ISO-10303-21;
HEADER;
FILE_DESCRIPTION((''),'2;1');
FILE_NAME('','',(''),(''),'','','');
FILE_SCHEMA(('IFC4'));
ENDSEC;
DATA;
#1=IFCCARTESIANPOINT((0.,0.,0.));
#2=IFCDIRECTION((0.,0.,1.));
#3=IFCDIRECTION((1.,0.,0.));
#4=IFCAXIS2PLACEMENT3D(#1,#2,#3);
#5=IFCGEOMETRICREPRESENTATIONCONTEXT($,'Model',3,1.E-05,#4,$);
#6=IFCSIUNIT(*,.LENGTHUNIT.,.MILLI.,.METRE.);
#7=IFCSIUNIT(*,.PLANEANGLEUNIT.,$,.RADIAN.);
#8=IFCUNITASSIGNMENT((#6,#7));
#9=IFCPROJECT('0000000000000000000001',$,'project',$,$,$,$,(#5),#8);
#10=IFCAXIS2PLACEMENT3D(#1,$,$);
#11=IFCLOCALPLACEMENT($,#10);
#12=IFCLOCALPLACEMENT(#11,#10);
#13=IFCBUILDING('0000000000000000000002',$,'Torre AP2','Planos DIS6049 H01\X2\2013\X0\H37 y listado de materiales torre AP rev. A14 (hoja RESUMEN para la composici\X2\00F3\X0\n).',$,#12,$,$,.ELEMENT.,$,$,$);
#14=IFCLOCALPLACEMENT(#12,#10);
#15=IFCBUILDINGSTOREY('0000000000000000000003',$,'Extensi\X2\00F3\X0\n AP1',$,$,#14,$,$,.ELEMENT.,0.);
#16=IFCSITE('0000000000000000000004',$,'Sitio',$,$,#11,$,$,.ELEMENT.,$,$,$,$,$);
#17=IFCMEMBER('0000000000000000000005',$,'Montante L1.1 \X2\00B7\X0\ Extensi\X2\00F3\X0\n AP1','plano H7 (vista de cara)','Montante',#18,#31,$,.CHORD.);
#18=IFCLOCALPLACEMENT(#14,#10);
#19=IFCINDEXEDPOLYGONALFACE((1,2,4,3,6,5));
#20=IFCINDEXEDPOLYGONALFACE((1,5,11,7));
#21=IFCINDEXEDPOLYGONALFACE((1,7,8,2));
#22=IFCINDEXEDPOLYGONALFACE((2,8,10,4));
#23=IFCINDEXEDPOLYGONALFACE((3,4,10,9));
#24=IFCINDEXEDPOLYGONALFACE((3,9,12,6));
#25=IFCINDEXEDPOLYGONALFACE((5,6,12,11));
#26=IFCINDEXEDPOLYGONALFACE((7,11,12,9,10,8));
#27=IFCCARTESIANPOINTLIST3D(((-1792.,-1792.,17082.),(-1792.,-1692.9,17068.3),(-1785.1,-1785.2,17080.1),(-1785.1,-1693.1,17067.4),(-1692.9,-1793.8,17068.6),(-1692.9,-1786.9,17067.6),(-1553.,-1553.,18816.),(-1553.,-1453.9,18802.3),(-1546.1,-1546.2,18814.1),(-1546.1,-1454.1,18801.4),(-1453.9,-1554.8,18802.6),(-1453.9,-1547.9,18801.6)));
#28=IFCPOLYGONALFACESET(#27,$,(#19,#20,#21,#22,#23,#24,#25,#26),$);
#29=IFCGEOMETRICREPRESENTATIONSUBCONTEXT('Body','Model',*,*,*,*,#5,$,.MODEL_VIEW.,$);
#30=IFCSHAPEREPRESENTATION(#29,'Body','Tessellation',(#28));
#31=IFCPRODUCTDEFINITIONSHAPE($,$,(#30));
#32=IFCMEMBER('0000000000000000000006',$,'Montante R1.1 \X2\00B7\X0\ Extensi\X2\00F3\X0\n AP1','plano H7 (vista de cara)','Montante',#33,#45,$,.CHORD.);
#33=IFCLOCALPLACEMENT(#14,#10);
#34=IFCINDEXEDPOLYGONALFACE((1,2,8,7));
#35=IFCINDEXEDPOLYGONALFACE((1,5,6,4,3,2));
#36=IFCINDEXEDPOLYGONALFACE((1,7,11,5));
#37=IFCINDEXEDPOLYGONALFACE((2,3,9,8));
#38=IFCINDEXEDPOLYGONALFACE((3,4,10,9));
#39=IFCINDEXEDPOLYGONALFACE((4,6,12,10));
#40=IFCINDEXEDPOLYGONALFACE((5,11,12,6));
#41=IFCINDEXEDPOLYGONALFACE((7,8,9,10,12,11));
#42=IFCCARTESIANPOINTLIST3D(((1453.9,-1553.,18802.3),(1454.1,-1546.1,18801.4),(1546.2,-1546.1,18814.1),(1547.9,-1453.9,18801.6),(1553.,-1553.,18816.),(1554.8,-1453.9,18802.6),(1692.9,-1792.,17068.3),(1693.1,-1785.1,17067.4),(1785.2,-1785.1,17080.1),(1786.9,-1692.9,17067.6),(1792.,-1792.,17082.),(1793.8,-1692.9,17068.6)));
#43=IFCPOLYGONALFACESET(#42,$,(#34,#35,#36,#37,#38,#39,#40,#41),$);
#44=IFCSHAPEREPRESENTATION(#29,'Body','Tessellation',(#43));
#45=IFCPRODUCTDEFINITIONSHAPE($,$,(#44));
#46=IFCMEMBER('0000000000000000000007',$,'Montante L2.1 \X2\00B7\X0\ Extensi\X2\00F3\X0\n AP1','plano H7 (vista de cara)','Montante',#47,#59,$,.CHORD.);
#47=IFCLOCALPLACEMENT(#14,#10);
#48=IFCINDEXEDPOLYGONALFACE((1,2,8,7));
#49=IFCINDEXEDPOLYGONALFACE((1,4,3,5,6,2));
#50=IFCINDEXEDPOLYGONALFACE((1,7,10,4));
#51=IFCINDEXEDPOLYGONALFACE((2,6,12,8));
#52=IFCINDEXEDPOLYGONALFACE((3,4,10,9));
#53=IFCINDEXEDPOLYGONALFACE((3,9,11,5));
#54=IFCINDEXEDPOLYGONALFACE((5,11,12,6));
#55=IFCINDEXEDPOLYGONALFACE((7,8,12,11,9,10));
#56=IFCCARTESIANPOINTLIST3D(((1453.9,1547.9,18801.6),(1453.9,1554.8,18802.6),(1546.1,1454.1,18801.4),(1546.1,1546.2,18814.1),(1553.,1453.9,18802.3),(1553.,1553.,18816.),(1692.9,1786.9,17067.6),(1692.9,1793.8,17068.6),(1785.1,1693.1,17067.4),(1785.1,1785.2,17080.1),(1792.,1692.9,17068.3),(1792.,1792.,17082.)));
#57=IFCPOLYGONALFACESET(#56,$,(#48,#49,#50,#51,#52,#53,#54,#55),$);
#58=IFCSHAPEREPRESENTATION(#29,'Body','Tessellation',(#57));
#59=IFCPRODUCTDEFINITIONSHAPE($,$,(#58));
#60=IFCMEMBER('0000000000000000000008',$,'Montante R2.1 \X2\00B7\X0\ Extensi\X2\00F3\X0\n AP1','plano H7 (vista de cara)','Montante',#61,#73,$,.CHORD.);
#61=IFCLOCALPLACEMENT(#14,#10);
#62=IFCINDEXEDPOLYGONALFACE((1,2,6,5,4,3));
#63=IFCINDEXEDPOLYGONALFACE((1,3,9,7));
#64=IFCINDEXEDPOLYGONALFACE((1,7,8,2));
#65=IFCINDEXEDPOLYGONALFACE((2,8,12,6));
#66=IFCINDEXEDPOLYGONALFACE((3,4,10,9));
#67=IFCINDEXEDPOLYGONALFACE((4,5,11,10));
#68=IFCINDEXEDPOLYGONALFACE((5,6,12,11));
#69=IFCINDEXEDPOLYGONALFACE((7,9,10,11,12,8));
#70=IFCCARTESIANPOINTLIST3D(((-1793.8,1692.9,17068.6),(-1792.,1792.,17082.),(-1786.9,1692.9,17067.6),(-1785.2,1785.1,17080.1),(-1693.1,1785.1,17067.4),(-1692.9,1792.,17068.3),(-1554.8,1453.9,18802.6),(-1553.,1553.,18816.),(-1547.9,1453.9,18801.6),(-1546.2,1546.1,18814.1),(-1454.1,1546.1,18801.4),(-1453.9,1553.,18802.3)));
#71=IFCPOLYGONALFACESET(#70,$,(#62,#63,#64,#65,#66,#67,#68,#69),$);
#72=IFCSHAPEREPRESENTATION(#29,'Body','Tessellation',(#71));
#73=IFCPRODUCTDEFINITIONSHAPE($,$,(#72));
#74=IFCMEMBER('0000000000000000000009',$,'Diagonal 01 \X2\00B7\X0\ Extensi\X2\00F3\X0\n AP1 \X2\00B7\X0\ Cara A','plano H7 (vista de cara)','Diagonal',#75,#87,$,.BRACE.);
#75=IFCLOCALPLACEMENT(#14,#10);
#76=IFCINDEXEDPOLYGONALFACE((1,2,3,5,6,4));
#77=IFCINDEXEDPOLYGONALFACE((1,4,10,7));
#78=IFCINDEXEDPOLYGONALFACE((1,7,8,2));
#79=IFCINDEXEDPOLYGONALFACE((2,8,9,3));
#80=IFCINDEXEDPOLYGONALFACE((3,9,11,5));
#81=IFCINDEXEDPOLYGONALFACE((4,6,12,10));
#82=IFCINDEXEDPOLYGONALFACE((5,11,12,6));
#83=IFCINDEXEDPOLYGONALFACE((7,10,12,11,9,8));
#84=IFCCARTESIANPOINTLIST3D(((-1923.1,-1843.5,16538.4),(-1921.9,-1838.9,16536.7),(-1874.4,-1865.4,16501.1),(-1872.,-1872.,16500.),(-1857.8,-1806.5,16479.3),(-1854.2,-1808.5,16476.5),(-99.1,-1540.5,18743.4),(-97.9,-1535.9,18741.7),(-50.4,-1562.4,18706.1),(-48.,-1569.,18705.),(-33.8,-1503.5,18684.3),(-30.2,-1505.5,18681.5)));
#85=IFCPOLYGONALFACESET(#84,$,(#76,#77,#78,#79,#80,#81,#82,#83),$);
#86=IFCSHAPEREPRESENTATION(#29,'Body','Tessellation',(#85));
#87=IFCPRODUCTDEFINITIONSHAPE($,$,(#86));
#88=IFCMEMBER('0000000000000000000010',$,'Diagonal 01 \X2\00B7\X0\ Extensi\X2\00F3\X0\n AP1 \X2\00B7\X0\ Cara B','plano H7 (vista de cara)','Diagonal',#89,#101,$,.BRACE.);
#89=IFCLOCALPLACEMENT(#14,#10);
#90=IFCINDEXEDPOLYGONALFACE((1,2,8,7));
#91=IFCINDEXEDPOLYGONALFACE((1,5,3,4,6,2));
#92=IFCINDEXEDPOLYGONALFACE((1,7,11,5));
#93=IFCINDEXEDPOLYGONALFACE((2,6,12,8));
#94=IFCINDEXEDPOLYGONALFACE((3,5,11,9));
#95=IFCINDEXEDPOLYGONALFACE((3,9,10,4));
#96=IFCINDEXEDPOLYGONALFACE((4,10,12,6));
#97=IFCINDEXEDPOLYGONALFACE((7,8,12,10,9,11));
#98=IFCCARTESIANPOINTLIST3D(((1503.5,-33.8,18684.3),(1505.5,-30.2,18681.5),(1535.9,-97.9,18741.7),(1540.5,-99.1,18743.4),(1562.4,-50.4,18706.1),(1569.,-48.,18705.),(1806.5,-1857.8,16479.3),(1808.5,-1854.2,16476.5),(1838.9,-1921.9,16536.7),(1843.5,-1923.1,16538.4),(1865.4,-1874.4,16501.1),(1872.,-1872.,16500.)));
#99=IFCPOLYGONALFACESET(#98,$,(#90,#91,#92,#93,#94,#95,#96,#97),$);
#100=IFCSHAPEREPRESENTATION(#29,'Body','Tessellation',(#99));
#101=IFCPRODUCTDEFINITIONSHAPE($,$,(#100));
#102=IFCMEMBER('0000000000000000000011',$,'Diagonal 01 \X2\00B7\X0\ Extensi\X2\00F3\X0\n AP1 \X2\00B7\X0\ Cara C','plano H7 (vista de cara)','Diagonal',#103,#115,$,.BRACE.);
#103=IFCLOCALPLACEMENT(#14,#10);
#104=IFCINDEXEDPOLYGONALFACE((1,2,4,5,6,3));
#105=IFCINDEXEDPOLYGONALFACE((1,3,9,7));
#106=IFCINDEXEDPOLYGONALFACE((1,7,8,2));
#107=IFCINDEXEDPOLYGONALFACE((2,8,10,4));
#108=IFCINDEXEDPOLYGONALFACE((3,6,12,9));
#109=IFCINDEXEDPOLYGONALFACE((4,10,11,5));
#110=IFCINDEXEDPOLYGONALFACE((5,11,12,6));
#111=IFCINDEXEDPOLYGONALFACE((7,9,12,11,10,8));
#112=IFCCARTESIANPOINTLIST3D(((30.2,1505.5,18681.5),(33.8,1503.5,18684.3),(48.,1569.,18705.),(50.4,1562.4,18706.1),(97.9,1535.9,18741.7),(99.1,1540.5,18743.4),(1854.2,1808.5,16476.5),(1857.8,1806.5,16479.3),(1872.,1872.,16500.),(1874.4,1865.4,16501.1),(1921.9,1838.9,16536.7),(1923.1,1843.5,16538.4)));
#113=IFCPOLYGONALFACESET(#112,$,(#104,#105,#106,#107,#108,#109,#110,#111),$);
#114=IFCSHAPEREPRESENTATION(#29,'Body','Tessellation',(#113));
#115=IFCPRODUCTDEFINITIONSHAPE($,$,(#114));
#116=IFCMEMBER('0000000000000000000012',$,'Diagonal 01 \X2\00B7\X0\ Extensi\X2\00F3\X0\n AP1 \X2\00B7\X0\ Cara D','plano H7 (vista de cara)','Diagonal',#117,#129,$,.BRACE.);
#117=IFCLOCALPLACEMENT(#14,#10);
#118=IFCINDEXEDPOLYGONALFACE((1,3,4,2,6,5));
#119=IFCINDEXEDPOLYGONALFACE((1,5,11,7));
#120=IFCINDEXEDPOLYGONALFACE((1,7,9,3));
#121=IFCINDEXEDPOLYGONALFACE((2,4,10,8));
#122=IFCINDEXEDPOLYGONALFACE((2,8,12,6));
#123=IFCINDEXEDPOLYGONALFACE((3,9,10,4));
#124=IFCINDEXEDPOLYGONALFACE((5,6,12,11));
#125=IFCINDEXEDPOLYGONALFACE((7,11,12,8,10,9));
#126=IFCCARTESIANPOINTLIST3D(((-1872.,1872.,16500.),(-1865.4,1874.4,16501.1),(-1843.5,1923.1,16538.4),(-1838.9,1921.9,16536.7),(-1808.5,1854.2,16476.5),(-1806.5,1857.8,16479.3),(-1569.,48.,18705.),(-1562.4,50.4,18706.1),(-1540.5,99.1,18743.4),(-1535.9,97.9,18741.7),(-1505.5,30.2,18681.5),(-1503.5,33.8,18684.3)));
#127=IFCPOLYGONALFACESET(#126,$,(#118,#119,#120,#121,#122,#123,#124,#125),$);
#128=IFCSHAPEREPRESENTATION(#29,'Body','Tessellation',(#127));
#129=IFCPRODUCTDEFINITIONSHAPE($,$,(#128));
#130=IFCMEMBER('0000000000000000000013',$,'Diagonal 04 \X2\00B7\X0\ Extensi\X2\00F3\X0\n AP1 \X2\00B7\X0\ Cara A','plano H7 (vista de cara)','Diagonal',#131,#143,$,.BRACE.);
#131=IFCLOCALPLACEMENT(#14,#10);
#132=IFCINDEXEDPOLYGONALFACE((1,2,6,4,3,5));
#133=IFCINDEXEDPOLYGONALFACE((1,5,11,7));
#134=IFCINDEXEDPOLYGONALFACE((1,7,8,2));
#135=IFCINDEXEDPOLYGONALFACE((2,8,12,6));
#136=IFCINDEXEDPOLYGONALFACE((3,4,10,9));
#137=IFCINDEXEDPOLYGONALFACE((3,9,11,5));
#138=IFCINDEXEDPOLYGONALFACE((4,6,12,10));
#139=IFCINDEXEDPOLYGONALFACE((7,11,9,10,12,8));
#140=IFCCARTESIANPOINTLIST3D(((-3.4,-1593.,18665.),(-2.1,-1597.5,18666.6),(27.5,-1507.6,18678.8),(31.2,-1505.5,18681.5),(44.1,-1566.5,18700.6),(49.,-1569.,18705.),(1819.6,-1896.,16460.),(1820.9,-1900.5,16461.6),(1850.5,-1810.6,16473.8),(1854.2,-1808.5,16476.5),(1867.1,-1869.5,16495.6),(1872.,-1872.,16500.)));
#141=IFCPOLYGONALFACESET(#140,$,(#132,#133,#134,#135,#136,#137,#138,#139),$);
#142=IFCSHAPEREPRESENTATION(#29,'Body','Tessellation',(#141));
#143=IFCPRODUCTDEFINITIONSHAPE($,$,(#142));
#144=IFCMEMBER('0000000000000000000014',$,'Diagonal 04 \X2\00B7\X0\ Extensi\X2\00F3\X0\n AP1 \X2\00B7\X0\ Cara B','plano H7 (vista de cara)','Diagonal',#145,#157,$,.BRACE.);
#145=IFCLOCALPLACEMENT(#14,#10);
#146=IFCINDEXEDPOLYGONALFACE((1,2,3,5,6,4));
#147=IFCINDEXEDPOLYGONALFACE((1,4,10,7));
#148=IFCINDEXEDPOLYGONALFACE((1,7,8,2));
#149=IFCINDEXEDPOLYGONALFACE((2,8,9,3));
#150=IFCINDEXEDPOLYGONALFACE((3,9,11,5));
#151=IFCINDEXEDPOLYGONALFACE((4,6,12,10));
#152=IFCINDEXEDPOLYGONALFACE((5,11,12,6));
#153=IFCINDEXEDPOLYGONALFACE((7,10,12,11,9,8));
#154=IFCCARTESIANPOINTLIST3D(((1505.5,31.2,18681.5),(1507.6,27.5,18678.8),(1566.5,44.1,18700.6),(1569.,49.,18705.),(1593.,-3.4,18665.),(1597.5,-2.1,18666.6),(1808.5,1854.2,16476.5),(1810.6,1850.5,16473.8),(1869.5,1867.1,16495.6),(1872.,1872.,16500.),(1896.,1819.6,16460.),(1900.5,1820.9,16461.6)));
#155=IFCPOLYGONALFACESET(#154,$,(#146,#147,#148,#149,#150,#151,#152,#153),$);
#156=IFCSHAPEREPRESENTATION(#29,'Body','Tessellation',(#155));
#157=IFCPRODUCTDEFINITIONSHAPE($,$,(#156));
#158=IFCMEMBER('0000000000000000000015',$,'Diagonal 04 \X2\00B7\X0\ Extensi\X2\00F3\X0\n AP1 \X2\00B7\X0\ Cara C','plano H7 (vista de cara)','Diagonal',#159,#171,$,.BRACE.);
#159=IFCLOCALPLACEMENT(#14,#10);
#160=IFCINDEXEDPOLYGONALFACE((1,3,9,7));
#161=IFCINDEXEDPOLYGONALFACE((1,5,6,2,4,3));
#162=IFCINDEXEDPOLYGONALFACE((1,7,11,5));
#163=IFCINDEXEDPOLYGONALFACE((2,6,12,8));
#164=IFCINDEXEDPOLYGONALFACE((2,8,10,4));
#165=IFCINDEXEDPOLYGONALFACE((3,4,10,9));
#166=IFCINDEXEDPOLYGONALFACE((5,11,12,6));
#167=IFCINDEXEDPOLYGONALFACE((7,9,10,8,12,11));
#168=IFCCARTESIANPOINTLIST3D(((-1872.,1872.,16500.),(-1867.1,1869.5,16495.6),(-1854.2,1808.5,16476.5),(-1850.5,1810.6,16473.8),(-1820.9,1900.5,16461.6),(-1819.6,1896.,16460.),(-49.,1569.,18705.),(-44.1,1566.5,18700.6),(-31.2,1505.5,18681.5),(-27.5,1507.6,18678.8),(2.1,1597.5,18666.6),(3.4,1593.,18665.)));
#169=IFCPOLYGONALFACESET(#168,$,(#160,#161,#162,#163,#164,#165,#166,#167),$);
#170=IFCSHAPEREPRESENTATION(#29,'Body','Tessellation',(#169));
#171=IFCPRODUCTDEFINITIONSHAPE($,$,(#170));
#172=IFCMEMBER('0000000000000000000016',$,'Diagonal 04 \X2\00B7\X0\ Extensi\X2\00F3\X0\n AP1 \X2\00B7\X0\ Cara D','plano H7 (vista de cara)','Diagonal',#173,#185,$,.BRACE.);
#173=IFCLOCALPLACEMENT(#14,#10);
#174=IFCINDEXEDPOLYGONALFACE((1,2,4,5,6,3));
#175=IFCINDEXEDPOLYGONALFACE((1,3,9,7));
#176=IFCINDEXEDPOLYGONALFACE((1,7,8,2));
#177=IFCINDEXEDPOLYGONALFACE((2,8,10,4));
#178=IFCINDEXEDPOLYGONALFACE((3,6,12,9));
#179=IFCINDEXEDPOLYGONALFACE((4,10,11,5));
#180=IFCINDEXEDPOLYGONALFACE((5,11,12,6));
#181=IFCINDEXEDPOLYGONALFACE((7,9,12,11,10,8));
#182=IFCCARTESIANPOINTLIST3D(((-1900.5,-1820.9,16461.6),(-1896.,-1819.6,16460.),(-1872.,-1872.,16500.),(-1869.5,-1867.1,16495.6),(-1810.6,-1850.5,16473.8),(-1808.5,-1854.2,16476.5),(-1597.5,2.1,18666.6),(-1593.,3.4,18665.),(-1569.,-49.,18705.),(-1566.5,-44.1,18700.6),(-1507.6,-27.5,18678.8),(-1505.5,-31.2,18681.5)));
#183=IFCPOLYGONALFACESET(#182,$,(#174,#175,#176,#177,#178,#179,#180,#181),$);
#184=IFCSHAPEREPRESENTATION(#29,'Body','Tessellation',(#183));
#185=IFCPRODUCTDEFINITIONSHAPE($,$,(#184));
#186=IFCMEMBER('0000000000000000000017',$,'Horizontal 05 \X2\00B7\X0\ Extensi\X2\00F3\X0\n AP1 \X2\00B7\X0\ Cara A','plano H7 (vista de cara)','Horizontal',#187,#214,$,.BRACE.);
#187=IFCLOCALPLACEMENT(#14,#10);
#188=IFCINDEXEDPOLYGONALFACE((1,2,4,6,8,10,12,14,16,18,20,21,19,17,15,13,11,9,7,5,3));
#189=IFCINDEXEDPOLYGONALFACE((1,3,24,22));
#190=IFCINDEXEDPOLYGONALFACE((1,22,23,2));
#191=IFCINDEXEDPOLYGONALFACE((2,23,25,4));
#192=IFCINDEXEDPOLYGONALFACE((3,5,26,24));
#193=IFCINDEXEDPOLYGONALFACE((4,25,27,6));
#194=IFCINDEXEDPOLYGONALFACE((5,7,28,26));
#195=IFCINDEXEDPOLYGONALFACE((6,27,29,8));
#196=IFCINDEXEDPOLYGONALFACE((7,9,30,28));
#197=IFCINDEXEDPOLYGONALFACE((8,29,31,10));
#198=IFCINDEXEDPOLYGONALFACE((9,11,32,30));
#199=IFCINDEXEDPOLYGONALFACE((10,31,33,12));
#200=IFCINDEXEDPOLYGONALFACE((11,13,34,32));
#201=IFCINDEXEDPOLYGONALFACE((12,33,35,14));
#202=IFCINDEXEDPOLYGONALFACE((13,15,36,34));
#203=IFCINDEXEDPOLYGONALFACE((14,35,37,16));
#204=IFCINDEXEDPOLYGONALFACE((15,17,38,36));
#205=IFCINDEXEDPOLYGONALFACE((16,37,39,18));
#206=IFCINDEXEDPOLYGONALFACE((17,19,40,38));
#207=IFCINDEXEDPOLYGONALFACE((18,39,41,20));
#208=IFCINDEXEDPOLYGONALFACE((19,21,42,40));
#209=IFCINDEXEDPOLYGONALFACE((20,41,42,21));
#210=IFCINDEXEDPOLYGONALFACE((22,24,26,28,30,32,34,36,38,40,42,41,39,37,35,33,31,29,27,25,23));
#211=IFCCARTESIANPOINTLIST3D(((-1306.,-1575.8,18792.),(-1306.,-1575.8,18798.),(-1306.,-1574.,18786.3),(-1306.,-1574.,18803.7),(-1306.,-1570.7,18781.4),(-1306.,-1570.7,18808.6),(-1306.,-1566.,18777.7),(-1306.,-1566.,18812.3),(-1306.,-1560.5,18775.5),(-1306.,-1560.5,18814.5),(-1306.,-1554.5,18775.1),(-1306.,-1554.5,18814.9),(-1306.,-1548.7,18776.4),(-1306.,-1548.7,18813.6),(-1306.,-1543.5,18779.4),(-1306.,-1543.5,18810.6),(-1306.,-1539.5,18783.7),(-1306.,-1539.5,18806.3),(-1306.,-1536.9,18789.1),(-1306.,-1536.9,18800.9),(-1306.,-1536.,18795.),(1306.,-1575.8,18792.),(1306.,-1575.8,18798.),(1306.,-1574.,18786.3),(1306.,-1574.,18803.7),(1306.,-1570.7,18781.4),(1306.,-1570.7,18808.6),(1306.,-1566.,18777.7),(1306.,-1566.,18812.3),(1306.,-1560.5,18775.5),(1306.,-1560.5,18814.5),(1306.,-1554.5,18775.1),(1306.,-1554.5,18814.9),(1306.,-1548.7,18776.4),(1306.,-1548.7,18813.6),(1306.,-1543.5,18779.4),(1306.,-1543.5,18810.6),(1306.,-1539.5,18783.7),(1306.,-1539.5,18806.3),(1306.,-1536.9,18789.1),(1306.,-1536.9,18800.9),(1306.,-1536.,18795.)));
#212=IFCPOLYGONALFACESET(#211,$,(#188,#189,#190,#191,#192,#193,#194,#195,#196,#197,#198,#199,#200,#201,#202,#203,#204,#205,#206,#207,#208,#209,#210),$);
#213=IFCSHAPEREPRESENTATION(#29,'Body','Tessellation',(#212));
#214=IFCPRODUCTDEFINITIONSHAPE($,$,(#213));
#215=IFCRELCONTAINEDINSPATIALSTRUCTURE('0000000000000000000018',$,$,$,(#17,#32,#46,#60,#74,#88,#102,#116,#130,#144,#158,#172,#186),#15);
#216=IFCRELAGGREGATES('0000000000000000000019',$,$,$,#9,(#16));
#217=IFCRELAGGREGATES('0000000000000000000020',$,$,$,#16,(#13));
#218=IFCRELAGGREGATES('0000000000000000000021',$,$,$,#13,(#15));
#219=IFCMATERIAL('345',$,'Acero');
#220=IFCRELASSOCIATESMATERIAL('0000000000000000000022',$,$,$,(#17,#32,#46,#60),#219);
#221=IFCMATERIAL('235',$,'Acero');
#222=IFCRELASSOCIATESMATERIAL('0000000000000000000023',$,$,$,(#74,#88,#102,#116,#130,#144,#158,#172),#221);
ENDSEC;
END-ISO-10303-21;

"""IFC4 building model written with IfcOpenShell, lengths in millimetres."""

from ifc_helpers import new_model, si_unit, frame, frame_2d, origin, origin_with_axes, place, context, subcontext, project, spatial, circle, l_section, extrude, material, element, save


model = new_model("IFC4")

# Units and contexts
model_context = context("Model", 3, precision=1e-05, world=origin_with_axes())
body_context = subcontext(model_context, "Body", "Model", "MODEL_VIEW")
ifc_project = project(units=[si_unit("LENGTHUNIT", "METRE", prefix="MILLI"), si_unit("PLANEANGLEUNIT", "RADIAN")], contexts=[model_context])

# Site, building, storey
site_placement = place(None, origin())
site = spatial("IfcSite", under=ifc_project, at=site_placement, Name="Sitio", CompositionType="ELEMENT")
building_placement = place(site_placement, origin())
building = spatial("IfcBuilding", under=site, at=building_placement, Name="Torre AP2", Description="Planos DIS6049 H01–H37 y listado de materiales torre AP rev. A14 (hoja RESUMEN para la composición).", CompositionType="ELEMENT")
storey_placement = place(building_placement, origin())
storey = spatial("IfcBuildingStorey", under=building, at=storey_placement, Name="Extensión AP1", CompositionType="ELEMENT", Elevation=0.0)

# Members
ifc_material_1 = material(Name="345", Category="Acero")
for number, where, z_axis, x_axis, name in (
    (1, (-1792.0, -1792.0, 17082.0), (0.135285, 0.135285, 0.981527), (0.990807, -0.018472, -0.134018), "Montante L1.1 · Extensión AP1"),
    (2, (1792.0, -1792.0, 17082.0), (-0.135285, 0.135285, 0.981527), (0.018472, 0.990807, -0.134018), "Montante R1.1 · Extensión AP1"),
    (3, (1792.0, 1792.0, 17082.0), (-0.135285, -0.135285, 0.981527), (-0.990807, 0.018472, -0.134018), "Montante L2.1 · Extensión AP1"),
    (4, (-1792.0, 1792.0, 17082.0), (0.135285, -0.135285, 0.981527), (-0.018472, -0.990807, -0.134018), "Montante R2.1 · Extensión AP1"),
):
    element("IfcMember", number, at=place(storey_placement, frame(where, z_axis=z_axis, x_axis=x_axis)), inside=storey, material=ifc_material_1, Name=name, Description="plano H7 (vista de cara)", ObjectType="Montante", PredefinedType="CHORD", context=body_context, shape_type="SweptSolid", body=[
        extrude(l_section(Depth=100.0, Width=100.0, Thickness=7.0, at=frame_2d((50.0, 50.0))), None, (0.0, 0.0, 1.0), 1766.6),
    ])
ifc_material_2 = material(Name="235", Category="Acero")
for number, where, z_axis, x_axis, name in (
    (5, (-1872.0, -1872.0, 16500.0), (0.633853, 0.105295, 0.766253), (0.25455, 0.907102, -0.335216), "Diagonal 01 · Extensión AP1 · Cara A"),
    (6, (1872.0, -1872.0, 16500.0), (-0.105295, 0.633853, 0.766253), (-0.907102, 0.25455, -0.335216), "Diagonal 01 · Extensión AP1 · Cara B"),
    (7, (1872.0, 1872.0, 16500.0), (-0.633853, -0.105295, 0.766253), (-0.25455, -0.907102, -0.335216), "Diagonal 01 · Extensión AP1 · Cara C"),
    (8, (-1872.0, 1872.0, 16500.0), (0.105295, -0.633853, 0.766253), (0.907102, -0.25455, -0.335216), "Diagonal 01 · Extensión AP1 · Cara D"),
):
    element("IfcMember", number, at=place(storey_placement, frame(where, z_axis=z_axis, x_axis=x_axis)), inside=storey, material=ifc_material_2, Name=name, Description="plano H7 (vista de cara)", ObjectType="Diagonal", PredefinedType="BRACE", context=body_context, shape_type="SweptSolid", body=[
        extrude(l_section(Depth=70.0, Width=70.0, Thickness=5.0, at=frame_2d((35.0, 35.0))), None, (0.0, 0.0, 1.0), 2877.6),
    ])
for number, where, z_axis, x_axis, name in (
    (9, (1872.0, -1872.0, 16500.0), (-0.633645, 0.105318, 0.766422), (-0.254835, 0.906984, -0.33532), "Diagonal 04 · Extensión AP1 · Cara A"),
    (10, (1872.0, 1872.0, 16500.0), (-0.105318, -0.633645, 0.766422), (-0.906984, -0.254835, -0.33532), "Diagonal 04 · Extensión AP1 · Cara B"),
    (11, (-1872.0, 1872.0, 16500.0), (0.633645, -0.105318, 0.766422), (0.254835, -0.906984, -0.33532), "Diagonal 04 · Extensión AP1 · Cara C"),
    (12, (-1872.0, -1872.0, 16500.0), (0.105318, 0.633645, 0.766422), (0.906984, 0.254835, -0.33532), "Diagonal 04 · Extensión AP1 · Cara D"),
):
    element("IfcMember", number, at=place(storey_placement, frame(where, z_axis=z_axis, x_axis=x_axis)), inside=storey, material=ifc_material_2, Name=name, Description="plano H7 (vista de cara)", ObjectType="Diagonal", PredefinedType="BRACE", context=body_context, shape_type="SweptSolid", body=[
        extrude(l_section(Depth=70.0, Width=70.0, Thickness=5.0, at=frame_2d((35.0, 35.0))), None, (0.0, 0.0, 1.0), 2877.0),
    ])
for number, where, z_axis, x_axis, name in (
    (13, (1306.0, -1556.0, 18795.0), (-1.0, 0.0, 0.0), (0.0, 1.0, 0.0), "Horizontal 05 · Extensión AP1 · Cara A"),
):
    element("IfcMember", number, at=place(storey_placement, frame(where, z_axis=z_axis, x_axis=x_axis)), inside=storey, Name=name, Description="plano H7 (vista de cara)", ObjectType="Horizontal", PredefinedType="BRACE", context=body_context, shape_type="SweptSolid", body=[
        extrude(circle(Radius=20.0), None, (0.0, 0.0, 1.0), 2612.0),
    ])

save(model, "model.ifc")
